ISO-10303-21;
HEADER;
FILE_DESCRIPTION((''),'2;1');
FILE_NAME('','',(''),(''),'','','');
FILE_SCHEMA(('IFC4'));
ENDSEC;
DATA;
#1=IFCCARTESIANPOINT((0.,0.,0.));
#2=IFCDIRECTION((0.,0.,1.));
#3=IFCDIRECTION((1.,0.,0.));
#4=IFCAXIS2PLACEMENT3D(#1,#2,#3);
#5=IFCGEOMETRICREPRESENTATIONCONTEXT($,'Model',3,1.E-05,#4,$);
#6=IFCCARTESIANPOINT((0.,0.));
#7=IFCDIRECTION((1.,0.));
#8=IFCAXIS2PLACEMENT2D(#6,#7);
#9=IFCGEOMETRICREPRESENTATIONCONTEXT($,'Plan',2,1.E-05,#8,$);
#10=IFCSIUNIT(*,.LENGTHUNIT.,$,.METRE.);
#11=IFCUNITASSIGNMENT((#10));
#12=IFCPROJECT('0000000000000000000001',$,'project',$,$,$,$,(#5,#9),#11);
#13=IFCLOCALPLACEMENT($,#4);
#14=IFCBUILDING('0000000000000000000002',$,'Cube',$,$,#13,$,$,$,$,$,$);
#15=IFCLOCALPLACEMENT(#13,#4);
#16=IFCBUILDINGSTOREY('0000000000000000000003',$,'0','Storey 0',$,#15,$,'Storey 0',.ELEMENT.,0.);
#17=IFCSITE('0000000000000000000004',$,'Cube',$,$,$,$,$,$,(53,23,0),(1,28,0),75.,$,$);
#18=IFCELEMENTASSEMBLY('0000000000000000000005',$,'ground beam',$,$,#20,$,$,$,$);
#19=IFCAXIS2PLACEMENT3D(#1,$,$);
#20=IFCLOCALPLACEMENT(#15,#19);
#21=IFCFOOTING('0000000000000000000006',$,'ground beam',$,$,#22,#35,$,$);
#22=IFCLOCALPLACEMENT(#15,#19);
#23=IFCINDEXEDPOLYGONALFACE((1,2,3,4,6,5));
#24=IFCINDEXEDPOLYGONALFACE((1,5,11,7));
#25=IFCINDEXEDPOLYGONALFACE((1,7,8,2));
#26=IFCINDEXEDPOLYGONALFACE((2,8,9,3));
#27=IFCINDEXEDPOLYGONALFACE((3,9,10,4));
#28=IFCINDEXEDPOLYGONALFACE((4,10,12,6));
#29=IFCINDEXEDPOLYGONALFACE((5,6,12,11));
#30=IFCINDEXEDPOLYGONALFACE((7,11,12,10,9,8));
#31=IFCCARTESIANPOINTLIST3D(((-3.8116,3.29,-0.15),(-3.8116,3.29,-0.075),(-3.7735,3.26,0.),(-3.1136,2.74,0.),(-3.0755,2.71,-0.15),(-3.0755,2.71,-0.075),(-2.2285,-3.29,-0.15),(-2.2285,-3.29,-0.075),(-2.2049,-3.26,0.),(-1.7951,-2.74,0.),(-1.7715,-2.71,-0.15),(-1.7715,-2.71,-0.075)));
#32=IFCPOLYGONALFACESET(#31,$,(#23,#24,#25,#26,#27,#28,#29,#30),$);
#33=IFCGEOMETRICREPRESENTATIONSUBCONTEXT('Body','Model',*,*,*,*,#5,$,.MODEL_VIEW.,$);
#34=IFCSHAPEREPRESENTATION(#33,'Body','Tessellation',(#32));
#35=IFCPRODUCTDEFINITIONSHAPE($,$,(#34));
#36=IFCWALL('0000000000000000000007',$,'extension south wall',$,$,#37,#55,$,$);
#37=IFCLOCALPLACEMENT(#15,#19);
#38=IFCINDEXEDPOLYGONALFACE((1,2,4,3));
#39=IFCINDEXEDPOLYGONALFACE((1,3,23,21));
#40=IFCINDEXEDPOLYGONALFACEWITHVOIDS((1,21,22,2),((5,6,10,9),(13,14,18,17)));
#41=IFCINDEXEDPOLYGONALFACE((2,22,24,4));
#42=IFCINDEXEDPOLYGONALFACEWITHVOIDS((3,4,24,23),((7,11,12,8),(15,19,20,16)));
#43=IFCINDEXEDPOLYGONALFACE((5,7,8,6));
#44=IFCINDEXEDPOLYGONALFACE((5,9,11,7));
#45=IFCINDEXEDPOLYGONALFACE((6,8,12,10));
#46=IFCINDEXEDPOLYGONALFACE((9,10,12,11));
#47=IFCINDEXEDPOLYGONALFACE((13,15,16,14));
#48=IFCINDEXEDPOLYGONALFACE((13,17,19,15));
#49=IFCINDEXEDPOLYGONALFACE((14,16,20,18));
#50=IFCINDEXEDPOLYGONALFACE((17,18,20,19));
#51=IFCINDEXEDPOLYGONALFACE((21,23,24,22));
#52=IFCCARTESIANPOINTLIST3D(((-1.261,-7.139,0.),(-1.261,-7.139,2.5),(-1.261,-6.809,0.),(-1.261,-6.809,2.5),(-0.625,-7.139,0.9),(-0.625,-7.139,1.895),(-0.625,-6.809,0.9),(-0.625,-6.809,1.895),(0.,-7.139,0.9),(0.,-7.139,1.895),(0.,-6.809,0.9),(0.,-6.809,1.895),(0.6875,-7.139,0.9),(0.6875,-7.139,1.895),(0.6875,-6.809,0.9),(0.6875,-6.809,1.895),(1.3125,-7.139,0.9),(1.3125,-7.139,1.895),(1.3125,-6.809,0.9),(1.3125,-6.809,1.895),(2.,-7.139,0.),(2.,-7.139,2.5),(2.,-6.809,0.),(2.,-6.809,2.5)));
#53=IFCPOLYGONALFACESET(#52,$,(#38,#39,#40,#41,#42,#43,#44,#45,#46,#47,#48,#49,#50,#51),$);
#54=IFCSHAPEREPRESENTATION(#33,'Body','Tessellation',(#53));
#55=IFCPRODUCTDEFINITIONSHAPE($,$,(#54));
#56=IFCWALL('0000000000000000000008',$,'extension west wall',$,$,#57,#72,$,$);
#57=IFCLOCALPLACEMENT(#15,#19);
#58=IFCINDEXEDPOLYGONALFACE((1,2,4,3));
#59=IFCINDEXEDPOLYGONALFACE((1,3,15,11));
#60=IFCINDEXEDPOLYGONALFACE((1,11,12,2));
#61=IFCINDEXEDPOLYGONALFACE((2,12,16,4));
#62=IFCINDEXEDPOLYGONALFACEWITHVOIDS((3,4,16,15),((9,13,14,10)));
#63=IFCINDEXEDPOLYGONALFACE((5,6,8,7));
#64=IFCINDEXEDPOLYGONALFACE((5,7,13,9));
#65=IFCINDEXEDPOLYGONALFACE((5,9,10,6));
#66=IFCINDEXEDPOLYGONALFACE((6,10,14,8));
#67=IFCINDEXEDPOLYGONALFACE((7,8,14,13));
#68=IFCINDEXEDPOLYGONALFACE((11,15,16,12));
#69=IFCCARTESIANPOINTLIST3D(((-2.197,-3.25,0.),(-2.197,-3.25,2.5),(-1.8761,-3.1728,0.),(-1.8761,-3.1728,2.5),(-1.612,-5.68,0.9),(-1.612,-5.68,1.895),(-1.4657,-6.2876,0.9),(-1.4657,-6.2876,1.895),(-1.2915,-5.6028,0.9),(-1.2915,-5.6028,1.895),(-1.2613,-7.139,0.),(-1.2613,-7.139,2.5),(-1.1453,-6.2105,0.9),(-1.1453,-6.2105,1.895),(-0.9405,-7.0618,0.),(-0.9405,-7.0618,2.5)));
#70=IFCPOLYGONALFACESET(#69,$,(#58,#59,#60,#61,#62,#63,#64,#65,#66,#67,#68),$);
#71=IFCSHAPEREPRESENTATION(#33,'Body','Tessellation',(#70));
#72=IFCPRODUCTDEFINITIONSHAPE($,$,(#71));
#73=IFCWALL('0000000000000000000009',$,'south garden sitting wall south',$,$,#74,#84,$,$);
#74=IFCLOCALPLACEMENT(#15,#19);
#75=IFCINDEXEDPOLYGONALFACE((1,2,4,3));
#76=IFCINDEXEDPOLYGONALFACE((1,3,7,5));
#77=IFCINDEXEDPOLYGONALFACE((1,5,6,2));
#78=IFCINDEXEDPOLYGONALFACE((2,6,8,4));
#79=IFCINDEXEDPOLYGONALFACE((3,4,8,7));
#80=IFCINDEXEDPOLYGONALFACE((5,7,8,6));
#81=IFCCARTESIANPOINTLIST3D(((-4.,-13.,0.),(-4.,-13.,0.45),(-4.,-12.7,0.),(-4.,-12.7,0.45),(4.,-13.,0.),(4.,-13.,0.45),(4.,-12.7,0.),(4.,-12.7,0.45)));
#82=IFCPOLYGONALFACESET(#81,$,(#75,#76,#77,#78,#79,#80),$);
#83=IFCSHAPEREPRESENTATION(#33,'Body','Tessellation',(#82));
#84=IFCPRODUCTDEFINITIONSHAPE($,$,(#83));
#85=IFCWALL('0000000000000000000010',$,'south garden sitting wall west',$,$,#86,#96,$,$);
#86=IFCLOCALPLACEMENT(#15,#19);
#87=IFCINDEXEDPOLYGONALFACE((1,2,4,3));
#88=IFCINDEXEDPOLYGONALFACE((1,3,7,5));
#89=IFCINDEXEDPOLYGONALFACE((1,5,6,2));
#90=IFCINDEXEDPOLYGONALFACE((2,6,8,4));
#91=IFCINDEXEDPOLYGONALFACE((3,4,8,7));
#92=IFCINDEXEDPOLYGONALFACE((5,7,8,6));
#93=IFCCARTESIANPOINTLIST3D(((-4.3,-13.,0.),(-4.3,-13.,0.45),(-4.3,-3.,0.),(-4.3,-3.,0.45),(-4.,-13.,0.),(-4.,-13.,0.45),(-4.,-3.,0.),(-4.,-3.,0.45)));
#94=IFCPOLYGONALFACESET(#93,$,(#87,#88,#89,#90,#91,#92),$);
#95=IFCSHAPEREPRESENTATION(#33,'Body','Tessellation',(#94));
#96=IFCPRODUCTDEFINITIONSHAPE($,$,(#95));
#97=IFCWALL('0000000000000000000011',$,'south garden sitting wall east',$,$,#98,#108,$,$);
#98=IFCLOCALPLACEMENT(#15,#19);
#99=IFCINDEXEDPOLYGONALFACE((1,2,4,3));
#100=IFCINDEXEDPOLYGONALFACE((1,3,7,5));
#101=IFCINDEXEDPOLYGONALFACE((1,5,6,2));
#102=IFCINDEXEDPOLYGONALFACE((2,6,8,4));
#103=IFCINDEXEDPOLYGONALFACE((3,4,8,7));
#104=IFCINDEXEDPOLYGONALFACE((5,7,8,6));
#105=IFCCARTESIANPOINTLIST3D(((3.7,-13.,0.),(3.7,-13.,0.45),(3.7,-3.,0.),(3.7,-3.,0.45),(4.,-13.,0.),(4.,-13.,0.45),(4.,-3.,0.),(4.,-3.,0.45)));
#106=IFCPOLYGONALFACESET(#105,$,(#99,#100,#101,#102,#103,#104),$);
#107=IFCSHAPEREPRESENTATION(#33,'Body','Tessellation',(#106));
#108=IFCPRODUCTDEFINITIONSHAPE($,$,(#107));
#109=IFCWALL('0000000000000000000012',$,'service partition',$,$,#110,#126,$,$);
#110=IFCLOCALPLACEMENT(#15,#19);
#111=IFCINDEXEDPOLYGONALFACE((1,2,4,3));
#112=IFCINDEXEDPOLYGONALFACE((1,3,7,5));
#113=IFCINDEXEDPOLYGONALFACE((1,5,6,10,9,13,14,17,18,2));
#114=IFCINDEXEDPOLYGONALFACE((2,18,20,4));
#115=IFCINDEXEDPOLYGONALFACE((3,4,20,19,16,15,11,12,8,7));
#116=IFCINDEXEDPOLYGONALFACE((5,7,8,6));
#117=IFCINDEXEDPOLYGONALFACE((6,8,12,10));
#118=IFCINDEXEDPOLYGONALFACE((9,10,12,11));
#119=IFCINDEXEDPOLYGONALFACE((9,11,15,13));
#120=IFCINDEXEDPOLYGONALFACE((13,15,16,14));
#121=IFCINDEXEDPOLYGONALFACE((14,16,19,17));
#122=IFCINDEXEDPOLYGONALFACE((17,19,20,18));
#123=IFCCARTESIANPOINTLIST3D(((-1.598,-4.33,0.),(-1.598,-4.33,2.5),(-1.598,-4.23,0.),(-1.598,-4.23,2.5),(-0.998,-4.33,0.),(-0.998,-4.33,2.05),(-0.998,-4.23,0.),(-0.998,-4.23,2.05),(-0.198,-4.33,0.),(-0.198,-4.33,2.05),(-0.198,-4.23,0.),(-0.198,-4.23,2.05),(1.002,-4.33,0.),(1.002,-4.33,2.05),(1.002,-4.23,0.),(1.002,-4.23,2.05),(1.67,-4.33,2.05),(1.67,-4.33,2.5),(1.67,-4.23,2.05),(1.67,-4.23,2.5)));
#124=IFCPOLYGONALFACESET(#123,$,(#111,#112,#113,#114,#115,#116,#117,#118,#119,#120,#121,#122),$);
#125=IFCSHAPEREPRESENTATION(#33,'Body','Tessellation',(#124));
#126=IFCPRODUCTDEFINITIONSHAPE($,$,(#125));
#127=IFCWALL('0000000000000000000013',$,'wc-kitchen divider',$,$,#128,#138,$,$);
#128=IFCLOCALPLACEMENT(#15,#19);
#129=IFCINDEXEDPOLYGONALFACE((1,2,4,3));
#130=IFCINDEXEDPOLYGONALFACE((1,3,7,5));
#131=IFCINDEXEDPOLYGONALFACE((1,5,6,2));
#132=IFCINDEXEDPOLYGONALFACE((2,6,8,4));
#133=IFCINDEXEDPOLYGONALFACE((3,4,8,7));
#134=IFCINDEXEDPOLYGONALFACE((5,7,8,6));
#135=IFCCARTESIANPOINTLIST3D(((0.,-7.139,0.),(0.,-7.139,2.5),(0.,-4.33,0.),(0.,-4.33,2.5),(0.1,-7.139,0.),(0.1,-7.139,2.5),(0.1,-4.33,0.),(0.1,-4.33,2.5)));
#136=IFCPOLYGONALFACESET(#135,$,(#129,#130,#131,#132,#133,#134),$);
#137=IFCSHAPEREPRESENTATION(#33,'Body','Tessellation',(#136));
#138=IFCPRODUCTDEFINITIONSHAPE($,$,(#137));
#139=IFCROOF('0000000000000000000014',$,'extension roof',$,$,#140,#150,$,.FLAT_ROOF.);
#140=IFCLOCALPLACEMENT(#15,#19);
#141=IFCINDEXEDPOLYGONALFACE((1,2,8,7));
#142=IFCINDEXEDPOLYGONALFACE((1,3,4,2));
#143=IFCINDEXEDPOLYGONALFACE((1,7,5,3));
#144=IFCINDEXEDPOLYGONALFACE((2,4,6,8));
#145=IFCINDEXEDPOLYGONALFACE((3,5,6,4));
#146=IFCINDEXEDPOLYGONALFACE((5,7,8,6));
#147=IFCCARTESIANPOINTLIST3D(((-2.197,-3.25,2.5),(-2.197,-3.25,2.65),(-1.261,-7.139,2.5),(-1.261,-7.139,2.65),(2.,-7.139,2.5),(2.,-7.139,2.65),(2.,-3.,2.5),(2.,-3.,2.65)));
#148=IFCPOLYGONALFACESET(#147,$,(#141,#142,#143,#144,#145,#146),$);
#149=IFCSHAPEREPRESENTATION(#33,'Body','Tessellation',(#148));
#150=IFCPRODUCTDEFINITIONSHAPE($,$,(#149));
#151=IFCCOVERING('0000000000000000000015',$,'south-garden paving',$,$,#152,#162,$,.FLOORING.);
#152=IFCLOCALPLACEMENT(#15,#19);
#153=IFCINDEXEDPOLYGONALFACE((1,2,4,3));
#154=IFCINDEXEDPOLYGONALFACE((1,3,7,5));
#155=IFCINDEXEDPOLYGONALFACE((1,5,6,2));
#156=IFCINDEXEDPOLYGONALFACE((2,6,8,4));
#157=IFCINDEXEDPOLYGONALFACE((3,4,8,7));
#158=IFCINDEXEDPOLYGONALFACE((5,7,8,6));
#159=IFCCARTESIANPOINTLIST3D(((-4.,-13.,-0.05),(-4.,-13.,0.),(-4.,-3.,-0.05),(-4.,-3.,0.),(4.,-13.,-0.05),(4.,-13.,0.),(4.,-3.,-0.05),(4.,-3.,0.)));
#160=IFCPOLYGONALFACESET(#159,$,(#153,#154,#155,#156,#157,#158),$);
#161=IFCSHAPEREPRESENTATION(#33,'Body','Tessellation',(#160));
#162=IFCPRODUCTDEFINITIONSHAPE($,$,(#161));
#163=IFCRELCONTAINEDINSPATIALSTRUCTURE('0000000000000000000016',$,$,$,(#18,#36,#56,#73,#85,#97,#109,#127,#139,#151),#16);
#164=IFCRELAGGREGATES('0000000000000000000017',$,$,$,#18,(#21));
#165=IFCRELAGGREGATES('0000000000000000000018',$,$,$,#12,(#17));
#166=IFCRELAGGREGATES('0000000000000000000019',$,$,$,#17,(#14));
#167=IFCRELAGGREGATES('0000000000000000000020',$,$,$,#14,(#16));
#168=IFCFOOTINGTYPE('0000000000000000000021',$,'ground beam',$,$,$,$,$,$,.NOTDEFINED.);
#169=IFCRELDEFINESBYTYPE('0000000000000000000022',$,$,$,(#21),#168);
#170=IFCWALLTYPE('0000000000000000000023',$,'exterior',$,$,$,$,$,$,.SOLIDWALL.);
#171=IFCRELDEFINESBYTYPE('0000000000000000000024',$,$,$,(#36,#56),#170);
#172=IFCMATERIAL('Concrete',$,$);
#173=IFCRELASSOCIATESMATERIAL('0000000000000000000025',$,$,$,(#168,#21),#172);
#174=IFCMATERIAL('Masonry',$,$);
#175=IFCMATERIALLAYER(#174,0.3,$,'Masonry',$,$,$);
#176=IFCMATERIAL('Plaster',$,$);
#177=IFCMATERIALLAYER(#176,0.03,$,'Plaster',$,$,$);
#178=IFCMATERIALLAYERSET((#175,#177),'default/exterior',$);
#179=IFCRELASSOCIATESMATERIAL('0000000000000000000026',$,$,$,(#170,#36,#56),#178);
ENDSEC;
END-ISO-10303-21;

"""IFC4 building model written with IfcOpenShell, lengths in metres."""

from ifc_helpers import new_model, si_unit, frame, origin_with_axes, origin_2d_with_axis, place, context, subcontext, project, spatial, polyline, indexed_curve, outline, extrude, clip, halfspace, material, layer, layer_set, layer_usage, material_profile, profile_set, profile_usage, type_object, element, aggregate, save


model = new_model("IFC4")

# Units and contexts
model_context = context("Model", 3, precision=1e-05, world=origin_with_axes())
plan_context = context("Plan", 2, precision=1e-05, world=origin_2d_with_axis())
body_context_1 = subcontext(model_context, "Body", "Model", "MODEL_VIEW")
ifc_project = project(units=[si_unit("LENGTHUNIT", "METRE")], contexts=[model_context, plan_context])

# Site, building, storey
site = spatial("IfcSite", under=ifc_project, Name="Cube", RefLatitude=(53, 23, 0), RefLongitude=(1, 28, 0), RefElevation=75.0)
building_placement = place(None, origin_with_axes())
building = spatial("IfcBuilding", under=site, at=building_placement, Name="Cube")
storey_placement = place(building_placement, origin_with_axes())
storey = spatial("IfcBuildingStorey", under=building, at=storey_placement, Name="0", Description="Storey 0", LongName="Storey 0", CompositionType="ELEMENT", Elevation=0.0)

# Element assembly, footing
assembly_placement = place(storey_placement, origin_with_axes())
assembly = element("IfcElementAssembly", 1, at=assembly_placement, inside=storey, Name="ground beam")
ifc_material_1 = material(Name="Concrete")
ifc_material_profile = material_profile(ifc_material_1, outline(polyline([(-0.26, 0.0), (-0.29, -0.075), (-0.29, -0.15), (0.29, -0.15), (0.29, -0.075), (0.26, 0.0), (-0.26, 0.0)])))
ifc_profile_set = profile_set([ifc_material_profile])
ifc_profile_usage = profile_usage(ifc_profile_set)
footing_type = type_object("IfcFootingType", Name="ground beam", PredefinedType="NOTDEFINED", material=ifc_profile_set)
footing_placement = place(assembly_placement, frame((-1.7661, -3.9723, 0.0), z_axis=(-0.233915, 0.972257, 0.0), x_axis=(-0.972257, -0.233915, 0.0)))
footing = element("IfcFooting", 2, at=footing_placement, type_object=footing_type, material=ifc_profile_usage, Name="ground beam", context=body_context_1, shape_type="Clipping", body=[
    clip(clip(extrude(outline(polyline([(-0.26, 0.0), (-0.29, -0.075), (-0.29, -0.15), (0.29, -0.15), (0.29, -0.075), (0.26, 0.0), (-0.26, 0.0)])), origin_with_axes(), (0.0, 0.0, 1.0), 8.1712), halfspace(frame((0.0, 0.0, 1.0), z_axis=(-0.618904, 0.0, -0.785467), x_axis=(0.0, 1.0, 0.0)), False)), halfspace(frame((0.0, 0.0, 7.1712), z_axis=(-0.785467, 0.0, 0.618904), x_axis=(0.0, 1.0, 0.0)), False)),
])
aggregate(assembly, [footing])

# Wall, openings
ifc_material_2 = material(Name="Masonry")
ifc_layer_1 = layer(ifc_material_2, 0.3, Name="Masonry")
ifc_material_3 = material(Name="Plaster")
ifc_layer_2 = layer(ifc_material_3, 0.03, Name="Plaster")
ifc_layer_set = layer_set([ifc_layer_1, ifc_layer_2], Name="default/exterior")
ifc_layer_usage = layer_usage(ifc_layer_set, "AXIS2", "POSITIVE", 0.0)
wall_type = type_object("IfcWallType", Name="exterior", PredefinedType="SOLIDWALL", material=ifc_layer_set)
wall_1_placement = place(storey_placement, frame((-1.261, -7.139, 0.0), z_axis=(0.0, 0.0, 1.0), x_axis=(1.0, 0.0, 0.0)))
wall_1 = element("IfcWall", 3, at=wall_1_placement, inside=storey, type_object=wall_type, material=ifc_layer_usage, Name="extension south wall", context=body_context_1, shape_type="SweptSolid", body=[
    extrude(outline(indexed_curve([(0.0, 0.0), (0.0, 0.33), (3.261, 0.33), (3.261, 0.0), (0.0, 0.0)], self_intersect=False)), origin_with_axes(), (0.0, 0.0, 1.0), 2.5),
])
opening_1_placement = place(wall_1_placement, frame((0.636, 0.0, 0.9), z_axis=(0.0, 0.0, 1.0), x_axis=(1.0, 0.0, 0.0)))
element("IfcOpeningElement", 4, at=opening_1_placement, cuts=wall_1, PredefinedType="OPENING", context=body_context_1, shape_type="SweptSolid", body=[
    extrude(outline(indexed_curve([(0.0, 0.0), (0.0, 0.5), (0.625, 0.5), (0.625, 0.0), (0.0, 0.0)], self_intersect=False)), origin_with_axes(), (0.0, 0.0, 1.0), 0.995),
])
opening_2_placement = place(wall_1_placement, frame((1.9485, 0.0, 0.9), z_axis=(0.0, 0.0, 1.0), x_axis=(1.0, 0.0, 0.0)))
element("IfcOpeningElement", 5, at=opening_2_placement, cuts=wall_1, PredefinedType="OPENING", context=body_context_1, shape_type="SweptSolid", body=[
    extrude(outline(indexed_curve([(0.0, 0.0), (0.0, 0.5), (0.625, 0.5), (0.625, 0.0), (0.0, 0.0)], self_intersect=False)), origin_with_axes(), (0.0, 0.0, 1.0), 0.995),
])

# Wall, opening
wall_2_placement = place(storey_placement, frame((-2.197, -3.25, 0.0), z_axis=(0.0, 0.0, 1.0), x_axis=(0.233916, -0.972257, 0.0)))
wall_2 = element("IfcWall", 6, at=wall_2_placement, inside=storey, type_object=wall_type, material=ifc_layer_usage, Name="extension west wall", context=body_context_1, shape_type="SweptSolid", body=[
    extrude(outline(indexed_curve([(0.0, 0.0), (0.0, 0.33), (4.0, 0.33), (4.0, 0.0), (0.0, 0.0)], self_intersect=False)), origin_with_axes(), (0.0, 0.0, 1.0), 2.5),
])
opening_3_placement = place(wall_2_placement, frame((2.4994, 0.0003, 0.9), z_axis=(0.0, 0.0, 1.0), x_axis=(1.0, 0.000142, 0.0)))
element("IfcOpeningElement", 7, at=opening_3_placement, cuts=wall_2, PredefinedType="OPENING", context=body_context_1, shape_type="SweptSolid", body=[
    extrude(outline(indexed_curve([(0.0, 0.0), (0.0, 0.5), (0.625, 0.5), (0.625, 0.0), (0.0, 0.0)], self_intersect=False)), origin_with_axes(), (0.0, 0.0, 1.0), 0.995),
])

# Walls
wall_3_placement = place(storey_placement, frame((-4.0, -13.0, 0.0), z_axis=(0.0, 0.0, 1.0), x_axis=(1.0, 0.0, 0.0)))
element("IfcWall", 8, at=wall_3_placement, inside=storey, Name="south garden sitting wall south", context=body_context_1, shape_type="SweptSolid", body=[
    extrude(outline(indexed_curve([(0.0, 0.0), (0.0, 0.3), (8.0, 0.3), (8.0, 0.0), (0.0, 0.0)], self_intersect=False)), origin_with_axes(), (0.0, 0.0, 1.0), 0.45),
])
for number, where, z_axis, x_axis, name in (
    (9, (-4.0, -13.0, 0.0), (0.0, 0.0, 1.0), (0.0, 1.0, 0.0), "south garden sitting wall west"),
    (10, (4.0, -13.0, 0.0), (0.0, 0.0, 1.0), (0.0, 1.0, 0.0), "south garden sitting wall east"),
):
    element("IfcWall", number, at=place(storey_placement, frame(where, z_axis=z_axis, x_axis=x_axis)), inside=storey, Name=name, context=body_context_1, shape_type="SweptSolid", body=[
        extrude(outline(indexed_curve([(0.0, 0.0), (0.0, 0.3), (10.0, 0.3), (10.0, 0.0), (0.0, 0.0)], self_intersect=False)), origin_with_axes(), (0.0, 0.0, 1.0), 0.45),
    ])

# Wall, openings
wall_4_placement = place(storey_placement, frame((-1.598, -4.33, 0.0), z_axis=(0.0, 0.0, 1.0), x_axis=(1.0, 0.0, 0.0)))
wall_4 = element("IfcWall", 11, at=wall_4_placement, inside=storey, Name="service partition", context=body_context_1, shape_type="SweptSolid", body=[
    extrude(outline(indexed_curve([(0.0, 0.0), (0.0, 0.1), (3.268, 0.1), (3.268, 0.0), (0.0, 0.0)], self_intersect=False)), origin_with_axes(), (0.0, 0.0, 1.0), 2.5),
])
opening_4_placement = place(wall_4_placement, frame((0.6, -0.05, 0.0), z_axis=(0.0, 0.0, 1.0), x_axis=(1.0, 0.0, 0.0)))
element("IfcOpeningElement", 12, at=opening_4_placement, cuts=wall_4, context=body_context_1, shape_type="SweptSolid", body=[
    extrude(outline(indexed_curve([(0.0, 0.0), (0.0, 0.3), (0.8, 0.3), (0.8, 0.0), (0.0, 0.0)], self_intersect=False)), origin_with_axes(), (0.0, 0.0, 1.0), 2.05),
])
opening_5_placement = place(wall_4_placement, frame((2.6, -0.05, 0.0), z_axis=(0.0, 0.0, 1.0), x_axis=(1.0, 0.0, 0.0)))
element("IfcOpeningElement", 13, at=opening_5_placement, cuts=wall_4, context=body_context_1, shape_type="SweptSolid", body=[
    extrude(outline(indexed_curve([(0.0, 0.0), (0.0, 0.3), (0.8, 0.3), (0.8, 0.0), (0.0, 0.0)], self_intersect=False)), origin_with_axes(), (0.0, 0.0, 1.0), 2.05),
])

# Wall
wall_5_placement = place(storey_placement, frame((0.0, -4.33, 0.0), z_axis=(0.0, 0.0, 1.0), x_axis=(0.0, -1.0, 0.0)))
element("IfcWall", 14, at=wall_5_placement, inside=storey, Name="wc-kitchen divider", context=body_context_1, shape_type="SweptSolid", body=[
    extrude(outline(indexed_curve([(0.0, 0.0), (0.0, 0.1), (2.809, 0.1), (2.809, 0.0), (0.0, 0.0)], self_intersect=False)), origin_with_axes(), (0.0, 0.0, 1.0), 2.5),
])

# Roof
roof_placement = place(storey_placement, frame((-1.261, -7.139, 2.5), z_axis=(0.0, 0.0, 1.0), x_axis=(1.0, 0.0, 0.0)))
element("IfcRoof", 15, at=roof_placement, inside=storey, Name="extension roof", PredefinedType="FLAT_ROOF", context=body_context_1, shape_type="SweptSolid", body=[
    extrude(outline(indexed_curve([(0.0, 0.0), (3.261, 0.0), (3.261, 4.139), (-0.936, 3.889)])), None, (0.0, 0.0, 1.0), 0.15),
])

# Covering
covering_placement = place(storey_placement, frame((-4.0, -13.0, 0.0), z_axis=(0.0, 0.0, 1.0), x_axis=(1.0, 0.0, 0.0)))
element("IfcCovering", 16, at=covering_placement, inside=storey, Name="south-garden paving", PredefinedType="FLOORING", context=body_context_1, shape_type="SweptSolid", body=[
    extrude(outline(indexed_curve([(0.0, 0.0), (8.0, 0.0), (8.0, 10.0), (0.0, 10.0)])), None, (0.0, 0.0, -1.0), 0.05),
])

save(model, "model.ifc")
